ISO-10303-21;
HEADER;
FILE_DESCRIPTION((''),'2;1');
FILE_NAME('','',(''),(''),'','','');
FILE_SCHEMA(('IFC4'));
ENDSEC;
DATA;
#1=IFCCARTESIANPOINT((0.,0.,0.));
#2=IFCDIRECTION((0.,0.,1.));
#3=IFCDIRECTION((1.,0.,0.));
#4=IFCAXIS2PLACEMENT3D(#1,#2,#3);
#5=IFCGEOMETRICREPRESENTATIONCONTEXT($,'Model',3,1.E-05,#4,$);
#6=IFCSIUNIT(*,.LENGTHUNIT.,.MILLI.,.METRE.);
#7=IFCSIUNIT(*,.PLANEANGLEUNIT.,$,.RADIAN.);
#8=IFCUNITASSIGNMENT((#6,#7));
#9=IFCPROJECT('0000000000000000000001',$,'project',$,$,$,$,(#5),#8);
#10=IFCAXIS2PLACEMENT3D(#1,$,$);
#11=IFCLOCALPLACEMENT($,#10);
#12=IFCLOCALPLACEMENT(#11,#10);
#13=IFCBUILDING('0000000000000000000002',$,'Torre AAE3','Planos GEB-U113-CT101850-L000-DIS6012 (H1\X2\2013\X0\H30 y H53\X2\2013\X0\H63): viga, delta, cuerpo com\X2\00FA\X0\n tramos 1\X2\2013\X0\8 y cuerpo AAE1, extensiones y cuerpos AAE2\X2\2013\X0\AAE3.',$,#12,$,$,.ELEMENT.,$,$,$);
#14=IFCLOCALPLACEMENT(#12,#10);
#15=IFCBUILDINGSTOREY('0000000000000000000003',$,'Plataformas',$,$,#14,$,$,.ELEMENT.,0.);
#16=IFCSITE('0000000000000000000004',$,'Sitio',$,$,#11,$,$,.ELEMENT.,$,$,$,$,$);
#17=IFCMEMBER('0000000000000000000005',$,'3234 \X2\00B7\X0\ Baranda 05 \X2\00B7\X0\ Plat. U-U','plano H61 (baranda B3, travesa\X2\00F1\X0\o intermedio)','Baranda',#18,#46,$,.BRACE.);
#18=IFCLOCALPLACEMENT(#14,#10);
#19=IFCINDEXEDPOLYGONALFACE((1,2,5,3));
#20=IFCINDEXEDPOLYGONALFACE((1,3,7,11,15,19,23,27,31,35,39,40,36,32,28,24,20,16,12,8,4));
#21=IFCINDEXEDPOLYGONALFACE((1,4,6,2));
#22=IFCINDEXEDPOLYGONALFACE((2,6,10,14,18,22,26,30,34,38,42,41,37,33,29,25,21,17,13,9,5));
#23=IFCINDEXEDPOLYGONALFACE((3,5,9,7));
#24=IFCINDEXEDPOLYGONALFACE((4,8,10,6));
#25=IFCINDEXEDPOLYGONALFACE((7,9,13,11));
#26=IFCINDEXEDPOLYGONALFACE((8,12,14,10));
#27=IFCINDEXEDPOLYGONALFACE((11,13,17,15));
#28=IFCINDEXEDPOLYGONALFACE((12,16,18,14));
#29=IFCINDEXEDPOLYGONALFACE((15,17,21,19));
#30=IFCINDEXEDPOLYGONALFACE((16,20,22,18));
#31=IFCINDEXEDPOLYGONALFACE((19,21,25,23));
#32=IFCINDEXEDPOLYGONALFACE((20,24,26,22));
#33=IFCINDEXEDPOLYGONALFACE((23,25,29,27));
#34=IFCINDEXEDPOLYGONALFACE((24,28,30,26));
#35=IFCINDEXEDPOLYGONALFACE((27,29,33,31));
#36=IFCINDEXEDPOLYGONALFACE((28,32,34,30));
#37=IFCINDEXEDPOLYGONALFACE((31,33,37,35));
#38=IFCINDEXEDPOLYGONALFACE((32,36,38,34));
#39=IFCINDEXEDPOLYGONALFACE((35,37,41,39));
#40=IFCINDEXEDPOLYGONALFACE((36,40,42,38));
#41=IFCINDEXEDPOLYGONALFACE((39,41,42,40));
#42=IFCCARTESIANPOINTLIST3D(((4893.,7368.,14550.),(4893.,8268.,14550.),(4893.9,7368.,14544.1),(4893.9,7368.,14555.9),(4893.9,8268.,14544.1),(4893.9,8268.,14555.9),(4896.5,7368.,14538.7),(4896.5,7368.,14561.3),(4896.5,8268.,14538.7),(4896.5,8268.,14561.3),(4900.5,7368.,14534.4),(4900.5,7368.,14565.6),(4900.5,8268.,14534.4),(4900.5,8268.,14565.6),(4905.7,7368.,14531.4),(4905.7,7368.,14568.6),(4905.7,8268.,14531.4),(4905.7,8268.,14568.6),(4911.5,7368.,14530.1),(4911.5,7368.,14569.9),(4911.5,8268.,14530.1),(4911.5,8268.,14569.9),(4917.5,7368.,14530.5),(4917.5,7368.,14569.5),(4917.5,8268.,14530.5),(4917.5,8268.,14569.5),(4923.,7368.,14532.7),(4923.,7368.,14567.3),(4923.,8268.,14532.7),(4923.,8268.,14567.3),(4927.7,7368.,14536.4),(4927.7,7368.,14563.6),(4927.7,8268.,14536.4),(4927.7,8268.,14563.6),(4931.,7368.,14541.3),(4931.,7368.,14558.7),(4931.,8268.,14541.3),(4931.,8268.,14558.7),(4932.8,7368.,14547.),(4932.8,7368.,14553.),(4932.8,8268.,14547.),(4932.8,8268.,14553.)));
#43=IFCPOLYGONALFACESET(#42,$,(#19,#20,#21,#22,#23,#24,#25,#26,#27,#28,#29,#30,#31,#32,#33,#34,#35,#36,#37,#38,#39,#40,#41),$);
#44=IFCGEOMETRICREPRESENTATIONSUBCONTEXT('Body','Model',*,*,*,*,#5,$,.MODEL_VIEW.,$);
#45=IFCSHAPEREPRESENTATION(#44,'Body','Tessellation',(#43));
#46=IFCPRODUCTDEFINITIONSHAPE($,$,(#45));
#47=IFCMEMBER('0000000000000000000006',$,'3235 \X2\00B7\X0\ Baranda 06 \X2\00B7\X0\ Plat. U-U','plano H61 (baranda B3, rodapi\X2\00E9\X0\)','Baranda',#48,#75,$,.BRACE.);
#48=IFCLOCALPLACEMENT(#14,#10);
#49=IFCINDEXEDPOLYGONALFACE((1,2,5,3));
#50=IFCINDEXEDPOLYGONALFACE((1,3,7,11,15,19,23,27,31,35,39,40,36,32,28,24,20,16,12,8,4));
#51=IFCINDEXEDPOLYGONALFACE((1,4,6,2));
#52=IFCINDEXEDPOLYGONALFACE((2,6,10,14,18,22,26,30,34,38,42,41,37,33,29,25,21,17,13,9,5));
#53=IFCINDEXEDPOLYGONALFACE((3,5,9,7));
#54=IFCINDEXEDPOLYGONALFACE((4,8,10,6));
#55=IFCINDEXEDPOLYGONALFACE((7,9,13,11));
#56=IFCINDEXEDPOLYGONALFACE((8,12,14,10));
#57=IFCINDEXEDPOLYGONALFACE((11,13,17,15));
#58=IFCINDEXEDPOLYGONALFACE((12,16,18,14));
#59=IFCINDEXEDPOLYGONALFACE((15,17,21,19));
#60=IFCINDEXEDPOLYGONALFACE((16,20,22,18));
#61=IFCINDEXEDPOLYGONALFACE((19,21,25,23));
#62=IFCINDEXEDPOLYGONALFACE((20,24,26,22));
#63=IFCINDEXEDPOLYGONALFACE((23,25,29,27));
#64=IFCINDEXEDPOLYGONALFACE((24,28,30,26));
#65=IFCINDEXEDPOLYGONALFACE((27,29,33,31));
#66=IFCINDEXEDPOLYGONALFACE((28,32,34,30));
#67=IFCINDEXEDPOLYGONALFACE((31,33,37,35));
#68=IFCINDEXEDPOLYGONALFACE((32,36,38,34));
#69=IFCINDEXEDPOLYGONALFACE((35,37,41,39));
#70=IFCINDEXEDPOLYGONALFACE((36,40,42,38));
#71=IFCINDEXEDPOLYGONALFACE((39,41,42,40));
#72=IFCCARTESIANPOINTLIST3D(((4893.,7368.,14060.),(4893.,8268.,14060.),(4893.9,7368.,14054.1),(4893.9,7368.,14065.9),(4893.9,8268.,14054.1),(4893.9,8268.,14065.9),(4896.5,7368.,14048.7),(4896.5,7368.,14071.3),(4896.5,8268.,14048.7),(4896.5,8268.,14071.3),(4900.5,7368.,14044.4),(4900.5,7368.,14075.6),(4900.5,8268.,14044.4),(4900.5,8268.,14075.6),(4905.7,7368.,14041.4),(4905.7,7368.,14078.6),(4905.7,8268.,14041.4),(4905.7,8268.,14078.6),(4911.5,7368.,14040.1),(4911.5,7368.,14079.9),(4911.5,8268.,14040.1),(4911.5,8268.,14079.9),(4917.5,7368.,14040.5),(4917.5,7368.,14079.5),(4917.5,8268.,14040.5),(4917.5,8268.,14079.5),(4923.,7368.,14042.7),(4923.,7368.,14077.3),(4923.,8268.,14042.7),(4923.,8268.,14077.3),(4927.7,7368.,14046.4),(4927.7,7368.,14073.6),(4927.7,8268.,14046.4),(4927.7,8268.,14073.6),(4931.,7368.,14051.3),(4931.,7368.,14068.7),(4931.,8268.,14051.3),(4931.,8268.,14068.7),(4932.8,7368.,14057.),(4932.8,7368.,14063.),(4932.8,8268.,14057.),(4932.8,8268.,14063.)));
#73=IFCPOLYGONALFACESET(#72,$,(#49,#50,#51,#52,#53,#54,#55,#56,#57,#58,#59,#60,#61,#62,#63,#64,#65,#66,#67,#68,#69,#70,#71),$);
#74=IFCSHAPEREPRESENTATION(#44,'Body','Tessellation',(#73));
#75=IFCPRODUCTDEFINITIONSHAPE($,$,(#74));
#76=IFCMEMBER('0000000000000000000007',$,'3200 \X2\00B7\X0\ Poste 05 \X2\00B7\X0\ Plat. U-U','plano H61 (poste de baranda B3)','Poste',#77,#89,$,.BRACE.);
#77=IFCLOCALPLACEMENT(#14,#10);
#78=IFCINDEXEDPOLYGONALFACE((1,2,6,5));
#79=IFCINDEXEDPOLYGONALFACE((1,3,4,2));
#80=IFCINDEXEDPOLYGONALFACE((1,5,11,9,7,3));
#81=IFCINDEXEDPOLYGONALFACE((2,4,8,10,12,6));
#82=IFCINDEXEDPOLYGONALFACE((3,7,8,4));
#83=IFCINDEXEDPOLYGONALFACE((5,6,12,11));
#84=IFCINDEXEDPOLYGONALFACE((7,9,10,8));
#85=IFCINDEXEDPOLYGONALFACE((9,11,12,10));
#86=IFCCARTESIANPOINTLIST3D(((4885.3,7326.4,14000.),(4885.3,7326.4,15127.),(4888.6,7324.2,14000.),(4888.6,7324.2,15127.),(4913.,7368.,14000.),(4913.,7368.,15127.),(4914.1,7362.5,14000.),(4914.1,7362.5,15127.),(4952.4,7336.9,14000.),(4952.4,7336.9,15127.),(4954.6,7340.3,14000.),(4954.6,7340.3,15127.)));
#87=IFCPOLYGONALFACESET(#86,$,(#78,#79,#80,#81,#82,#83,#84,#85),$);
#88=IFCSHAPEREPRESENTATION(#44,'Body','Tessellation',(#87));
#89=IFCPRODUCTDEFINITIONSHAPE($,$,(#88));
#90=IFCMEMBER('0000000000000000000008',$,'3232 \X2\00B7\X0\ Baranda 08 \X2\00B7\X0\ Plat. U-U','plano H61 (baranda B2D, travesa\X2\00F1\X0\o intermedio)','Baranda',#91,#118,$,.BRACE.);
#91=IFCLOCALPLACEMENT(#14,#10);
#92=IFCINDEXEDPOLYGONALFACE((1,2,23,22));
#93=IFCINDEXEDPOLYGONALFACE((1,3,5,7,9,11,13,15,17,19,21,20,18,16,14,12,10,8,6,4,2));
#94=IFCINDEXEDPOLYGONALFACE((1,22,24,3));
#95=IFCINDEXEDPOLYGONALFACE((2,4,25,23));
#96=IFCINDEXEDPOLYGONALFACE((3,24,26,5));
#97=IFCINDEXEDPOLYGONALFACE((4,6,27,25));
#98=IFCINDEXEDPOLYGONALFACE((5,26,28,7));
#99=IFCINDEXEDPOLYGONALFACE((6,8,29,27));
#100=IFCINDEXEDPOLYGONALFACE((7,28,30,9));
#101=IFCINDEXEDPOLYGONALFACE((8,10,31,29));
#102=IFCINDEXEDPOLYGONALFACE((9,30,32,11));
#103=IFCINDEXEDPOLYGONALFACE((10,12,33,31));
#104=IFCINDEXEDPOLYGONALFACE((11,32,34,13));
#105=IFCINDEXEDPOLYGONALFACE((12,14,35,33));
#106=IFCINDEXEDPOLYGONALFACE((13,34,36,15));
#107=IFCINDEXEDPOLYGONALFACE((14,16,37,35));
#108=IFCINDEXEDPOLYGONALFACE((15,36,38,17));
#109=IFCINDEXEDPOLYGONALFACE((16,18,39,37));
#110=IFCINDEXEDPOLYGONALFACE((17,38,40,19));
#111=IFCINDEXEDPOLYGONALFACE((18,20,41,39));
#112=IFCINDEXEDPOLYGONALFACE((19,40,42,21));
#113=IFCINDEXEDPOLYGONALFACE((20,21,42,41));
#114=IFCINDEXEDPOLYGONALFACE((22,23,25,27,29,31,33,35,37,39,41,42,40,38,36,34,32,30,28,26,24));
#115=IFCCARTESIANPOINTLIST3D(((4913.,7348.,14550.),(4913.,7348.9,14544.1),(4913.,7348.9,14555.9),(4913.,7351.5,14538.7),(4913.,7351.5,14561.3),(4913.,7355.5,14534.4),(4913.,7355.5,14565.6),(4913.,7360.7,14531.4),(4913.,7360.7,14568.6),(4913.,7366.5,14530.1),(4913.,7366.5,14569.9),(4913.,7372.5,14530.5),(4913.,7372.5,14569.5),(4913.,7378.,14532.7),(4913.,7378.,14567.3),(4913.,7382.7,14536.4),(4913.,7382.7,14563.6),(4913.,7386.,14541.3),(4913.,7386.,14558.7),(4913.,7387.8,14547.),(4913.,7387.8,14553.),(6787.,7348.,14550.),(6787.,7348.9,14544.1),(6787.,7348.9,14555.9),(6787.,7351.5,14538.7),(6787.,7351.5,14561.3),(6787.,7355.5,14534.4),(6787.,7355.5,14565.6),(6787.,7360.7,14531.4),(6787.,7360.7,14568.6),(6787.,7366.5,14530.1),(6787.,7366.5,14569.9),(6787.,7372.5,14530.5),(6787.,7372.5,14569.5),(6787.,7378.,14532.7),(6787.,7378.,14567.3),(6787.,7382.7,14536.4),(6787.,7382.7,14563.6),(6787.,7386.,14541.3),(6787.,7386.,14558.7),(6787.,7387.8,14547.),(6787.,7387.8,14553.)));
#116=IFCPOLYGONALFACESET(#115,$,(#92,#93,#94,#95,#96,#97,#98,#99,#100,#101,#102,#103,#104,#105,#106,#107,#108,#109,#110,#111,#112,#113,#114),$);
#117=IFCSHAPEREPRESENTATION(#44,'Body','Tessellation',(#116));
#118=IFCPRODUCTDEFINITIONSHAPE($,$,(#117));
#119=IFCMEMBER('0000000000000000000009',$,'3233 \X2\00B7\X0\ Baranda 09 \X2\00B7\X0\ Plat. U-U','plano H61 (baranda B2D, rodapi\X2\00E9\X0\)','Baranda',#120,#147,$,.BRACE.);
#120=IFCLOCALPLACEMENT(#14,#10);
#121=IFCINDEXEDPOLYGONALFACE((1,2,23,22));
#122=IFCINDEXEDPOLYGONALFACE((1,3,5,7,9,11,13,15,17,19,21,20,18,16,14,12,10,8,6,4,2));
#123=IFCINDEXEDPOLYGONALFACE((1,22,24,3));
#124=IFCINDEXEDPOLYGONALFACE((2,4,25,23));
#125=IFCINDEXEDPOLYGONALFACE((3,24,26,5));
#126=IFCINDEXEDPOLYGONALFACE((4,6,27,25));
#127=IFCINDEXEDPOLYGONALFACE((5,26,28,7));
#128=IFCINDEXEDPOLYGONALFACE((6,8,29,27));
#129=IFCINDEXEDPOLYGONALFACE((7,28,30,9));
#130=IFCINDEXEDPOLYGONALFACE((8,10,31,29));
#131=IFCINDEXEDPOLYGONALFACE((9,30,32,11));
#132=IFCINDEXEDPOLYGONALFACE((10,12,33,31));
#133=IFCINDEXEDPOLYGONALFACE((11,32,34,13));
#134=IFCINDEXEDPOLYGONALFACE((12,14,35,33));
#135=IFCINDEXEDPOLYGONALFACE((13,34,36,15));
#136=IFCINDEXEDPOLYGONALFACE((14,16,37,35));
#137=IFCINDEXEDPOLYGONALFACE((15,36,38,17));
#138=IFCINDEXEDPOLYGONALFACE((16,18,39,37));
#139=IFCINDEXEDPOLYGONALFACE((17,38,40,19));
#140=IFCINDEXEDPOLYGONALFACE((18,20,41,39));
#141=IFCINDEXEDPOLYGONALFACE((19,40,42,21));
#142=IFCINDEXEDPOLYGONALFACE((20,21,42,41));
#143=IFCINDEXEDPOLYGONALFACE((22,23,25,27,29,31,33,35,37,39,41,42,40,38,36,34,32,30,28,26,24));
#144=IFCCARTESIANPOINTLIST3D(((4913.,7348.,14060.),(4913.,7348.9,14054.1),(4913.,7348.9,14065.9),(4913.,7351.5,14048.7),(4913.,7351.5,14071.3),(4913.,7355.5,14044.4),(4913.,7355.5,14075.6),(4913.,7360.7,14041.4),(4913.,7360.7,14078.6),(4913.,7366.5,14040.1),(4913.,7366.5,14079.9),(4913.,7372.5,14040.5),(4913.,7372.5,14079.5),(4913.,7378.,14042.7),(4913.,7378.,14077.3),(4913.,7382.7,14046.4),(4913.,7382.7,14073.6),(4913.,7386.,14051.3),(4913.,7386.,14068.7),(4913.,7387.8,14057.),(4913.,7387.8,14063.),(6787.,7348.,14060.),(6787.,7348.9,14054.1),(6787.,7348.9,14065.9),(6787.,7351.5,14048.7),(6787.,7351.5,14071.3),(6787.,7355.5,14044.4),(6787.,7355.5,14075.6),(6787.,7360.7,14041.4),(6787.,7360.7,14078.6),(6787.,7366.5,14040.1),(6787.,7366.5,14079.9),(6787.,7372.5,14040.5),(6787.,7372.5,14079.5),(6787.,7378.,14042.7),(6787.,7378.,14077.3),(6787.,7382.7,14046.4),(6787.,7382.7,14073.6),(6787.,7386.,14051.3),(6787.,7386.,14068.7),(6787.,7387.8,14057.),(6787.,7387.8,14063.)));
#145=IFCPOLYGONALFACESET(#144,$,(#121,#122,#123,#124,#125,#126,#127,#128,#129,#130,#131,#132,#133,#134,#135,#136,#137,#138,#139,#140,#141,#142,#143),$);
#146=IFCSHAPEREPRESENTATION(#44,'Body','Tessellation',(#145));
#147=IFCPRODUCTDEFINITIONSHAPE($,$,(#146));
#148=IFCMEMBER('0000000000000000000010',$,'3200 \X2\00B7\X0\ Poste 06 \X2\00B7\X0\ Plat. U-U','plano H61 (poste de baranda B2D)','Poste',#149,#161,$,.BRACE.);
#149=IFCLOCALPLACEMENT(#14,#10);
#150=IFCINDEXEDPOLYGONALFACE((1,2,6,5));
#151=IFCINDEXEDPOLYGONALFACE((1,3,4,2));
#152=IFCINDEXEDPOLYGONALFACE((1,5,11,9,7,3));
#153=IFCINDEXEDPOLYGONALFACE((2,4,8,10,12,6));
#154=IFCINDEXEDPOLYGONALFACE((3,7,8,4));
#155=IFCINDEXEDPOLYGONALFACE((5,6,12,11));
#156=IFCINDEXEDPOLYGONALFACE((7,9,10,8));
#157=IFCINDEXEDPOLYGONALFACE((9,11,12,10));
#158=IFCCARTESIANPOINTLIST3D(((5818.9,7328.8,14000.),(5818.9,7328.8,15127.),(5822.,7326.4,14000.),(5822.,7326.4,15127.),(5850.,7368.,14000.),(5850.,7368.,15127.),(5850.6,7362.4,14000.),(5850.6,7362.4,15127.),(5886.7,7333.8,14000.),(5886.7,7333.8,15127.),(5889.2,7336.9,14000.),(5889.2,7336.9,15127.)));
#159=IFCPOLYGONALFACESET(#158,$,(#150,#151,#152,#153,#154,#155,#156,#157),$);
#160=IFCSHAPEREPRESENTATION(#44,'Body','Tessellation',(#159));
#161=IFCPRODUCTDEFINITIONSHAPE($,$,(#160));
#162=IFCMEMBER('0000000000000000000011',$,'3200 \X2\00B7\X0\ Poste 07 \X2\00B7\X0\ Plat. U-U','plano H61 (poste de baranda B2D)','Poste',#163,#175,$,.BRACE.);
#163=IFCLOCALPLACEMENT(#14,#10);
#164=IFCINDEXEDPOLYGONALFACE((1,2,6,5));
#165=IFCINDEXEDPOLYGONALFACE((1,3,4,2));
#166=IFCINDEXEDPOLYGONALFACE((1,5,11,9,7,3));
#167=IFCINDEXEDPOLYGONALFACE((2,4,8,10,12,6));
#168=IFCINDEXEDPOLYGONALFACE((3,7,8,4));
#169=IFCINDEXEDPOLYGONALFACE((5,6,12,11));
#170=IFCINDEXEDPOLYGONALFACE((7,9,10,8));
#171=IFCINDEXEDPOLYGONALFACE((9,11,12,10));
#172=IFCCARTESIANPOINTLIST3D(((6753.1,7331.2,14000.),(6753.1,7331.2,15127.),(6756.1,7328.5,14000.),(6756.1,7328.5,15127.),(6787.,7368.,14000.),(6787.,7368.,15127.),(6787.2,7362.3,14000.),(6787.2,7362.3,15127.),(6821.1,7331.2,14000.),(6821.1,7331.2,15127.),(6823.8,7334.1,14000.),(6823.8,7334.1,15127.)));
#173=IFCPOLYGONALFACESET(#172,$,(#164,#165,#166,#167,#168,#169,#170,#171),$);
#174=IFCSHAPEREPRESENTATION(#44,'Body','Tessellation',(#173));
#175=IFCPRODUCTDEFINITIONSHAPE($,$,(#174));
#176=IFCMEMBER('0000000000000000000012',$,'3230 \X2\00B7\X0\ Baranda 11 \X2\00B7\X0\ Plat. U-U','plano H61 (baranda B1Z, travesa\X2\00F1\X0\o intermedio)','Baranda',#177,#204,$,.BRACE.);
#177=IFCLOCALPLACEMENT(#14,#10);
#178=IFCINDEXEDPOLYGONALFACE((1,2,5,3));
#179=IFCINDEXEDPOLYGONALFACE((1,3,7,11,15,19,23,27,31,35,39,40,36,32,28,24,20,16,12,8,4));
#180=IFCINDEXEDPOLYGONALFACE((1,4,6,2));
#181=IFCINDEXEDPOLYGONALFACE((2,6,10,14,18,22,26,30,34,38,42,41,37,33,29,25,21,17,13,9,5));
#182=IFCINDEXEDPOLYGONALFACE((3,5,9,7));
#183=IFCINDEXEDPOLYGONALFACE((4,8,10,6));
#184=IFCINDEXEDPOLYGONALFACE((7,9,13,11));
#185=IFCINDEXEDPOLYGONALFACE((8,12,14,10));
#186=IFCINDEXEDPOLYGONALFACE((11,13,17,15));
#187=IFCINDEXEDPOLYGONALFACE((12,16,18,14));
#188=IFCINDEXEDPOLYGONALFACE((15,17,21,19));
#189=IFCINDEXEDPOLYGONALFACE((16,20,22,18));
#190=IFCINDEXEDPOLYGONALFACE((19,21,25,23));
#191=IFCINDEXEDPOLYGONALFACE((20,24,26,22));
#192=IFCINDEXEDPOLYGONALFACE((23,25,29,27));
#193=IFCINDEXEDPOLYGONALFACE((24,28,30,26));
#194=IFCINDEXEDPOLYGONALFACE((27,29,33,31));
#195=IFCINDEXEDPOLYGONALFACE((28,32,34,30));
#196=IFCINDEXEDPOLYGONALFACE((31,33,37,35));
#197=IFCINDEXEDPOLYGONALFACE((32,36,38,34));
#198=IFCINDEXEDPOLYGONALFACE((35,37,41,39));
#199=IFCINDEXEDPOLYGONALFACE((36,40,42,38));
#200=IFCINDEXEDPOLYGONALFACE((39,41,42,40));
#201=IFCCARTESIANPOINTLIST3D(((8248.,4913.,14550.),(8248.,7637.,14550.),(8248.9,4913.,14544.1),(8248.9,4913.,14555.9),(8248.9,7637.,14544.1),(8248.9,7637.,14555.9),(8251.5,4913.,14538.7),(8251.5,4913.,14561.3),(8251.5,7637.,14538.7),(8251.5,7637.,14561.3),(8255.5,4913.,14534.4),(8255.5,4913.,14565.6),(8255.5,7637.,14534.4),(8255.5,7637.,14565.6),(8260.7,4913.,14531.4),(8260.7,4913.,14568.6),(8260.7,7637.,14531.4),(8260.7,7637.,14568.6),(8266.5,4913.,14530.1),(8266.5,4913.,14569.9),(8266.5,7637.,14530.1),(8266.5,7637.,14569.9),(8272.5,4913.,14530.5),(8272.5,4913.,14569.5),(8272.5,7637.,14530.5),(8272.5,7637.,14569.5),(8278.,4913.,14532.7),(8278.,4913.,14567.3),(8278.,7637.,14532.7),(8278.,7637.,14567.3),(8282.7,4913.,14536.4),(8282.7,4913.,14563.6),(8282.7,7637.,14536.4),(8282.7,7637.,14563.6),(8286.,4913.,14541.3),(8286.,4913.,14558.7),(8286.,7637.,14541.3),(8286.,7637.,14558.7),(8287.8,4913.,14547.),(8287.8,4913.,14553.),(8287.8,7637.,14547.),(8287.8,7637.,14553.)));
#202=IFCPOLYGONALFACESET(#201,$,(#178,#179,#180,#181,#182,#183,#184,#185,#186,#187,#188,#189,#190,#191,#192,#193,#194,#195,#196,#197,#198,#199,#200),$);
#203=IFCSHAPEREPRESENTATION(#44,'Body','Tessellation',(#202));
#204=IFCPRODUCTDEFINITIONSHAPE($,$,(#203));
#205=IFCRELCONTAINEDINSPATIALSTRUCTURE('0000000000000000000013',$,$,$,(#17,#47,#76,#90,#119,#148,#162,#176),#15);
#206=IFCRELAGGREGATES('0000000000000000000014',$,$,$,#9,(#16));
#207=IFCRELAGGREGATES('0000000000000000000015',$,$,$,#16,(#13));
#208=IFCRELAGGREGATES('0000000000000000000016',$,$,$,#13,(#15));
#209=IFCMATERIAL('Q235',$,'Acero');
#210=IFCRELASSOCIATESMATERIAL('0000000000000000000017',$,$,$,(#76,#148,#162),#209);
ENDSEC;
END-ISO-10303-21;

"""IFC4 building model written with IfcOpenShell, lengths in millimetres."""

from ifc_helpers import new_model, si_unit, frame, frame_2d, origin, origin_with_axes, place, context, subcontext, project, spatial, circle, l_section, extrude, material, element, save


model = new_model("IFC4")

# Units and contexts
model_context = context("Model", 3, precision=1e-05, world=origin_with_axes())
body_context = subcontext(model_context, "Body", "Model", "MODEL_VIEW")
ifc_project = project(units=[si_unit("LENGTHUNIT", "METRE", prefix="MILLI"), si_unit("PLANEANGLEUNIT", "RADIAN")], contexts=[model_context])

# Site, building, storey
site_placement = place(None, origin())
site = spatial("IfcSite", under=ifc_project, at=site_placement, Name="Sitio", CompositionType="ELEMENT")
building_placement = place(site_placement, origin())
building = spatial("IfcBuilding", under=site, at=building_placement, Name="Torre AAE3", Description="Planos GEB-U113-CT101850-L000-DIS6012 (H1–H30 y H53–H63): viga, delta, cuerpo común tramos 1–8 y cuerpo AAE1, extensiones y cuerpos AAE2–AAE3.", CompositionType="ELEMENT")
storey_placement = place(building_placement, origin())
storey = spatial("IfcBuildingStorey", under=building, at=storey_placement, Name="Plataformas", CompositionType="ELEMENT", Elevation=0.0)

# Members
ifc_material = material(Name="Q235", Category="Acero")
for number, where, z_axis, x_axis, name, description in (
    (1, (4913.0, 8268.0, 14550.0), (0.0, -1.0, 0.0), (-1.0, 0.0, 0.0), "3234 · Baranda 05 · Plat. U-U", "plano H61 (baranda B3, travesaño intermedio)"),
    (2, (4913.0, 8268.0, 14060.0), (0.0, -1.0, 0.0), (-1.0, 0.0, 0.0), "3235 · Baranda 06 · Plat. U-U", "plano H61 (baranda B3, rodapié)"),
):
    element("IfcMember", number, at=place(storey_placement, frame(where, z_axis=z_axis, x_axis=x_axis)), inside=storey, Name=name, Description=description, ObjectType="Baranda", PredefinedType="BRACE", context=body_context, shape_type="SweptSolid", body=[
        extrude(circle(Radius=20.0), None, (0.0, 0.0, 1.0), 900.0),
    ])
member_1_placement = place(storey_placement, frame((4913.0, 7368.0, 14000.0), z_axis=(0.0, 0.0, 1.0), x_axis=(-0.554778, -0.831998, 0.0)))
element("IfcMember", 3, at=member_1_placement, inside=storey, material=ifc_material, Name="3200 · Poste 05 · Plat. U-U", Description="plano H61 (poste de baranda B3)", ObjectType="Poste", PredefinedType="BRACE", context=body_context, shape_type="SweptSolid", body=[
    extrude(l_section(Depth=50.0, Width=50.0, Thickness=4.0, at=frame_2d((25.0, 25.0))), None, (0.0, 0.0, 1.0), 1127.0),
])
for number, where, z_axis, x_axis, name, description in (
    (4, (4913.0, 7368.0, 14550.0), (1.0, 0.0, 0.0), (0.0, -1.0, 0.0), "3232 · Baranda 08 · Plat. U-U", "plano H61 (baranda B2D, travesaño intermedio)"),
    (5, (4913.0, 7368.0, 14060.0), (1.0, 0.0, 0.0), (0.0, -1.0, 0.0), "3233 · Baranda 09 · Plat. U-U", "plano H61 (baranda B2D, rodapié)"),
):
    element("IfcMember", number, at=place(storey_placement, frame(where, z_axis=z_axis, x_axis=x_axis)), inside=storey, Name=name, Description=description, ObjectType="Baranda", PredefinedType="BRACE", context=body_context, shape_type="SweptSolid", body=[
        extrude(circle(Radius=20.0), None, (0.0, 0.0, 1.0), 1874.0),
    ])
for number, where, z_axis, x_axis, name in (
    (6, (5850.0, 7368.0, 14000.0), (0.0, 0.0, 1.0), (-0.621813, -0.783166, 0.0), "3200 · Poste 06 · Plat. U-U"),
    (7, (6787.0, 7368.0, 14000.0), (0.0, 0.0, 1.0), (-0.677513, -0.735511, 0.0), "3200 · Poste 07 · Plat. U-U"),
):
    element("IfcMember", number, at=place(storey_placement, frame(where, z_axis=z_axis, x_axis=x_axis)), inside=storey, material=ifc_material, Name=name, Description="plano H61 (poste de baranda B2D)", ObjectType="Poste", PredefinedType="BRACE", context=body_context, shape_type="SweptSolid", body=[
        extrude(l_section(Depth=50.0, Width=50.0, Thickness=4.0, at=frame_2d((25.0, 25.0))), None, (0.0, 0.0, 1.0), 1127.0),
    ])
for number, where, z_axis, x_axis, name in (
    (8, (8268.0, 7637.0, 14550.0), (0.0, -1.0, 0.0), (-1.0, 0.0, 0.0), "3230 · Baranda 11 · Plat. U-U"),
):
    element("IfcMember", number, at=place(storey_placement, frame(where, z_axis=z_axis, x_axis=x_axis)), inside=storey, Name=name, Description="plano H61 (baranda B1Z, travesaño intermedio)", ObjectType="Baranda", PredefinedType="BRACE", context=body_context, shape_type="SweptSolid", body=[
        extrude(circle(Radius=20.0), None, (0.0, 0.0, 1.0), 2724.0),
    ])

save(model, "model.ifc")
